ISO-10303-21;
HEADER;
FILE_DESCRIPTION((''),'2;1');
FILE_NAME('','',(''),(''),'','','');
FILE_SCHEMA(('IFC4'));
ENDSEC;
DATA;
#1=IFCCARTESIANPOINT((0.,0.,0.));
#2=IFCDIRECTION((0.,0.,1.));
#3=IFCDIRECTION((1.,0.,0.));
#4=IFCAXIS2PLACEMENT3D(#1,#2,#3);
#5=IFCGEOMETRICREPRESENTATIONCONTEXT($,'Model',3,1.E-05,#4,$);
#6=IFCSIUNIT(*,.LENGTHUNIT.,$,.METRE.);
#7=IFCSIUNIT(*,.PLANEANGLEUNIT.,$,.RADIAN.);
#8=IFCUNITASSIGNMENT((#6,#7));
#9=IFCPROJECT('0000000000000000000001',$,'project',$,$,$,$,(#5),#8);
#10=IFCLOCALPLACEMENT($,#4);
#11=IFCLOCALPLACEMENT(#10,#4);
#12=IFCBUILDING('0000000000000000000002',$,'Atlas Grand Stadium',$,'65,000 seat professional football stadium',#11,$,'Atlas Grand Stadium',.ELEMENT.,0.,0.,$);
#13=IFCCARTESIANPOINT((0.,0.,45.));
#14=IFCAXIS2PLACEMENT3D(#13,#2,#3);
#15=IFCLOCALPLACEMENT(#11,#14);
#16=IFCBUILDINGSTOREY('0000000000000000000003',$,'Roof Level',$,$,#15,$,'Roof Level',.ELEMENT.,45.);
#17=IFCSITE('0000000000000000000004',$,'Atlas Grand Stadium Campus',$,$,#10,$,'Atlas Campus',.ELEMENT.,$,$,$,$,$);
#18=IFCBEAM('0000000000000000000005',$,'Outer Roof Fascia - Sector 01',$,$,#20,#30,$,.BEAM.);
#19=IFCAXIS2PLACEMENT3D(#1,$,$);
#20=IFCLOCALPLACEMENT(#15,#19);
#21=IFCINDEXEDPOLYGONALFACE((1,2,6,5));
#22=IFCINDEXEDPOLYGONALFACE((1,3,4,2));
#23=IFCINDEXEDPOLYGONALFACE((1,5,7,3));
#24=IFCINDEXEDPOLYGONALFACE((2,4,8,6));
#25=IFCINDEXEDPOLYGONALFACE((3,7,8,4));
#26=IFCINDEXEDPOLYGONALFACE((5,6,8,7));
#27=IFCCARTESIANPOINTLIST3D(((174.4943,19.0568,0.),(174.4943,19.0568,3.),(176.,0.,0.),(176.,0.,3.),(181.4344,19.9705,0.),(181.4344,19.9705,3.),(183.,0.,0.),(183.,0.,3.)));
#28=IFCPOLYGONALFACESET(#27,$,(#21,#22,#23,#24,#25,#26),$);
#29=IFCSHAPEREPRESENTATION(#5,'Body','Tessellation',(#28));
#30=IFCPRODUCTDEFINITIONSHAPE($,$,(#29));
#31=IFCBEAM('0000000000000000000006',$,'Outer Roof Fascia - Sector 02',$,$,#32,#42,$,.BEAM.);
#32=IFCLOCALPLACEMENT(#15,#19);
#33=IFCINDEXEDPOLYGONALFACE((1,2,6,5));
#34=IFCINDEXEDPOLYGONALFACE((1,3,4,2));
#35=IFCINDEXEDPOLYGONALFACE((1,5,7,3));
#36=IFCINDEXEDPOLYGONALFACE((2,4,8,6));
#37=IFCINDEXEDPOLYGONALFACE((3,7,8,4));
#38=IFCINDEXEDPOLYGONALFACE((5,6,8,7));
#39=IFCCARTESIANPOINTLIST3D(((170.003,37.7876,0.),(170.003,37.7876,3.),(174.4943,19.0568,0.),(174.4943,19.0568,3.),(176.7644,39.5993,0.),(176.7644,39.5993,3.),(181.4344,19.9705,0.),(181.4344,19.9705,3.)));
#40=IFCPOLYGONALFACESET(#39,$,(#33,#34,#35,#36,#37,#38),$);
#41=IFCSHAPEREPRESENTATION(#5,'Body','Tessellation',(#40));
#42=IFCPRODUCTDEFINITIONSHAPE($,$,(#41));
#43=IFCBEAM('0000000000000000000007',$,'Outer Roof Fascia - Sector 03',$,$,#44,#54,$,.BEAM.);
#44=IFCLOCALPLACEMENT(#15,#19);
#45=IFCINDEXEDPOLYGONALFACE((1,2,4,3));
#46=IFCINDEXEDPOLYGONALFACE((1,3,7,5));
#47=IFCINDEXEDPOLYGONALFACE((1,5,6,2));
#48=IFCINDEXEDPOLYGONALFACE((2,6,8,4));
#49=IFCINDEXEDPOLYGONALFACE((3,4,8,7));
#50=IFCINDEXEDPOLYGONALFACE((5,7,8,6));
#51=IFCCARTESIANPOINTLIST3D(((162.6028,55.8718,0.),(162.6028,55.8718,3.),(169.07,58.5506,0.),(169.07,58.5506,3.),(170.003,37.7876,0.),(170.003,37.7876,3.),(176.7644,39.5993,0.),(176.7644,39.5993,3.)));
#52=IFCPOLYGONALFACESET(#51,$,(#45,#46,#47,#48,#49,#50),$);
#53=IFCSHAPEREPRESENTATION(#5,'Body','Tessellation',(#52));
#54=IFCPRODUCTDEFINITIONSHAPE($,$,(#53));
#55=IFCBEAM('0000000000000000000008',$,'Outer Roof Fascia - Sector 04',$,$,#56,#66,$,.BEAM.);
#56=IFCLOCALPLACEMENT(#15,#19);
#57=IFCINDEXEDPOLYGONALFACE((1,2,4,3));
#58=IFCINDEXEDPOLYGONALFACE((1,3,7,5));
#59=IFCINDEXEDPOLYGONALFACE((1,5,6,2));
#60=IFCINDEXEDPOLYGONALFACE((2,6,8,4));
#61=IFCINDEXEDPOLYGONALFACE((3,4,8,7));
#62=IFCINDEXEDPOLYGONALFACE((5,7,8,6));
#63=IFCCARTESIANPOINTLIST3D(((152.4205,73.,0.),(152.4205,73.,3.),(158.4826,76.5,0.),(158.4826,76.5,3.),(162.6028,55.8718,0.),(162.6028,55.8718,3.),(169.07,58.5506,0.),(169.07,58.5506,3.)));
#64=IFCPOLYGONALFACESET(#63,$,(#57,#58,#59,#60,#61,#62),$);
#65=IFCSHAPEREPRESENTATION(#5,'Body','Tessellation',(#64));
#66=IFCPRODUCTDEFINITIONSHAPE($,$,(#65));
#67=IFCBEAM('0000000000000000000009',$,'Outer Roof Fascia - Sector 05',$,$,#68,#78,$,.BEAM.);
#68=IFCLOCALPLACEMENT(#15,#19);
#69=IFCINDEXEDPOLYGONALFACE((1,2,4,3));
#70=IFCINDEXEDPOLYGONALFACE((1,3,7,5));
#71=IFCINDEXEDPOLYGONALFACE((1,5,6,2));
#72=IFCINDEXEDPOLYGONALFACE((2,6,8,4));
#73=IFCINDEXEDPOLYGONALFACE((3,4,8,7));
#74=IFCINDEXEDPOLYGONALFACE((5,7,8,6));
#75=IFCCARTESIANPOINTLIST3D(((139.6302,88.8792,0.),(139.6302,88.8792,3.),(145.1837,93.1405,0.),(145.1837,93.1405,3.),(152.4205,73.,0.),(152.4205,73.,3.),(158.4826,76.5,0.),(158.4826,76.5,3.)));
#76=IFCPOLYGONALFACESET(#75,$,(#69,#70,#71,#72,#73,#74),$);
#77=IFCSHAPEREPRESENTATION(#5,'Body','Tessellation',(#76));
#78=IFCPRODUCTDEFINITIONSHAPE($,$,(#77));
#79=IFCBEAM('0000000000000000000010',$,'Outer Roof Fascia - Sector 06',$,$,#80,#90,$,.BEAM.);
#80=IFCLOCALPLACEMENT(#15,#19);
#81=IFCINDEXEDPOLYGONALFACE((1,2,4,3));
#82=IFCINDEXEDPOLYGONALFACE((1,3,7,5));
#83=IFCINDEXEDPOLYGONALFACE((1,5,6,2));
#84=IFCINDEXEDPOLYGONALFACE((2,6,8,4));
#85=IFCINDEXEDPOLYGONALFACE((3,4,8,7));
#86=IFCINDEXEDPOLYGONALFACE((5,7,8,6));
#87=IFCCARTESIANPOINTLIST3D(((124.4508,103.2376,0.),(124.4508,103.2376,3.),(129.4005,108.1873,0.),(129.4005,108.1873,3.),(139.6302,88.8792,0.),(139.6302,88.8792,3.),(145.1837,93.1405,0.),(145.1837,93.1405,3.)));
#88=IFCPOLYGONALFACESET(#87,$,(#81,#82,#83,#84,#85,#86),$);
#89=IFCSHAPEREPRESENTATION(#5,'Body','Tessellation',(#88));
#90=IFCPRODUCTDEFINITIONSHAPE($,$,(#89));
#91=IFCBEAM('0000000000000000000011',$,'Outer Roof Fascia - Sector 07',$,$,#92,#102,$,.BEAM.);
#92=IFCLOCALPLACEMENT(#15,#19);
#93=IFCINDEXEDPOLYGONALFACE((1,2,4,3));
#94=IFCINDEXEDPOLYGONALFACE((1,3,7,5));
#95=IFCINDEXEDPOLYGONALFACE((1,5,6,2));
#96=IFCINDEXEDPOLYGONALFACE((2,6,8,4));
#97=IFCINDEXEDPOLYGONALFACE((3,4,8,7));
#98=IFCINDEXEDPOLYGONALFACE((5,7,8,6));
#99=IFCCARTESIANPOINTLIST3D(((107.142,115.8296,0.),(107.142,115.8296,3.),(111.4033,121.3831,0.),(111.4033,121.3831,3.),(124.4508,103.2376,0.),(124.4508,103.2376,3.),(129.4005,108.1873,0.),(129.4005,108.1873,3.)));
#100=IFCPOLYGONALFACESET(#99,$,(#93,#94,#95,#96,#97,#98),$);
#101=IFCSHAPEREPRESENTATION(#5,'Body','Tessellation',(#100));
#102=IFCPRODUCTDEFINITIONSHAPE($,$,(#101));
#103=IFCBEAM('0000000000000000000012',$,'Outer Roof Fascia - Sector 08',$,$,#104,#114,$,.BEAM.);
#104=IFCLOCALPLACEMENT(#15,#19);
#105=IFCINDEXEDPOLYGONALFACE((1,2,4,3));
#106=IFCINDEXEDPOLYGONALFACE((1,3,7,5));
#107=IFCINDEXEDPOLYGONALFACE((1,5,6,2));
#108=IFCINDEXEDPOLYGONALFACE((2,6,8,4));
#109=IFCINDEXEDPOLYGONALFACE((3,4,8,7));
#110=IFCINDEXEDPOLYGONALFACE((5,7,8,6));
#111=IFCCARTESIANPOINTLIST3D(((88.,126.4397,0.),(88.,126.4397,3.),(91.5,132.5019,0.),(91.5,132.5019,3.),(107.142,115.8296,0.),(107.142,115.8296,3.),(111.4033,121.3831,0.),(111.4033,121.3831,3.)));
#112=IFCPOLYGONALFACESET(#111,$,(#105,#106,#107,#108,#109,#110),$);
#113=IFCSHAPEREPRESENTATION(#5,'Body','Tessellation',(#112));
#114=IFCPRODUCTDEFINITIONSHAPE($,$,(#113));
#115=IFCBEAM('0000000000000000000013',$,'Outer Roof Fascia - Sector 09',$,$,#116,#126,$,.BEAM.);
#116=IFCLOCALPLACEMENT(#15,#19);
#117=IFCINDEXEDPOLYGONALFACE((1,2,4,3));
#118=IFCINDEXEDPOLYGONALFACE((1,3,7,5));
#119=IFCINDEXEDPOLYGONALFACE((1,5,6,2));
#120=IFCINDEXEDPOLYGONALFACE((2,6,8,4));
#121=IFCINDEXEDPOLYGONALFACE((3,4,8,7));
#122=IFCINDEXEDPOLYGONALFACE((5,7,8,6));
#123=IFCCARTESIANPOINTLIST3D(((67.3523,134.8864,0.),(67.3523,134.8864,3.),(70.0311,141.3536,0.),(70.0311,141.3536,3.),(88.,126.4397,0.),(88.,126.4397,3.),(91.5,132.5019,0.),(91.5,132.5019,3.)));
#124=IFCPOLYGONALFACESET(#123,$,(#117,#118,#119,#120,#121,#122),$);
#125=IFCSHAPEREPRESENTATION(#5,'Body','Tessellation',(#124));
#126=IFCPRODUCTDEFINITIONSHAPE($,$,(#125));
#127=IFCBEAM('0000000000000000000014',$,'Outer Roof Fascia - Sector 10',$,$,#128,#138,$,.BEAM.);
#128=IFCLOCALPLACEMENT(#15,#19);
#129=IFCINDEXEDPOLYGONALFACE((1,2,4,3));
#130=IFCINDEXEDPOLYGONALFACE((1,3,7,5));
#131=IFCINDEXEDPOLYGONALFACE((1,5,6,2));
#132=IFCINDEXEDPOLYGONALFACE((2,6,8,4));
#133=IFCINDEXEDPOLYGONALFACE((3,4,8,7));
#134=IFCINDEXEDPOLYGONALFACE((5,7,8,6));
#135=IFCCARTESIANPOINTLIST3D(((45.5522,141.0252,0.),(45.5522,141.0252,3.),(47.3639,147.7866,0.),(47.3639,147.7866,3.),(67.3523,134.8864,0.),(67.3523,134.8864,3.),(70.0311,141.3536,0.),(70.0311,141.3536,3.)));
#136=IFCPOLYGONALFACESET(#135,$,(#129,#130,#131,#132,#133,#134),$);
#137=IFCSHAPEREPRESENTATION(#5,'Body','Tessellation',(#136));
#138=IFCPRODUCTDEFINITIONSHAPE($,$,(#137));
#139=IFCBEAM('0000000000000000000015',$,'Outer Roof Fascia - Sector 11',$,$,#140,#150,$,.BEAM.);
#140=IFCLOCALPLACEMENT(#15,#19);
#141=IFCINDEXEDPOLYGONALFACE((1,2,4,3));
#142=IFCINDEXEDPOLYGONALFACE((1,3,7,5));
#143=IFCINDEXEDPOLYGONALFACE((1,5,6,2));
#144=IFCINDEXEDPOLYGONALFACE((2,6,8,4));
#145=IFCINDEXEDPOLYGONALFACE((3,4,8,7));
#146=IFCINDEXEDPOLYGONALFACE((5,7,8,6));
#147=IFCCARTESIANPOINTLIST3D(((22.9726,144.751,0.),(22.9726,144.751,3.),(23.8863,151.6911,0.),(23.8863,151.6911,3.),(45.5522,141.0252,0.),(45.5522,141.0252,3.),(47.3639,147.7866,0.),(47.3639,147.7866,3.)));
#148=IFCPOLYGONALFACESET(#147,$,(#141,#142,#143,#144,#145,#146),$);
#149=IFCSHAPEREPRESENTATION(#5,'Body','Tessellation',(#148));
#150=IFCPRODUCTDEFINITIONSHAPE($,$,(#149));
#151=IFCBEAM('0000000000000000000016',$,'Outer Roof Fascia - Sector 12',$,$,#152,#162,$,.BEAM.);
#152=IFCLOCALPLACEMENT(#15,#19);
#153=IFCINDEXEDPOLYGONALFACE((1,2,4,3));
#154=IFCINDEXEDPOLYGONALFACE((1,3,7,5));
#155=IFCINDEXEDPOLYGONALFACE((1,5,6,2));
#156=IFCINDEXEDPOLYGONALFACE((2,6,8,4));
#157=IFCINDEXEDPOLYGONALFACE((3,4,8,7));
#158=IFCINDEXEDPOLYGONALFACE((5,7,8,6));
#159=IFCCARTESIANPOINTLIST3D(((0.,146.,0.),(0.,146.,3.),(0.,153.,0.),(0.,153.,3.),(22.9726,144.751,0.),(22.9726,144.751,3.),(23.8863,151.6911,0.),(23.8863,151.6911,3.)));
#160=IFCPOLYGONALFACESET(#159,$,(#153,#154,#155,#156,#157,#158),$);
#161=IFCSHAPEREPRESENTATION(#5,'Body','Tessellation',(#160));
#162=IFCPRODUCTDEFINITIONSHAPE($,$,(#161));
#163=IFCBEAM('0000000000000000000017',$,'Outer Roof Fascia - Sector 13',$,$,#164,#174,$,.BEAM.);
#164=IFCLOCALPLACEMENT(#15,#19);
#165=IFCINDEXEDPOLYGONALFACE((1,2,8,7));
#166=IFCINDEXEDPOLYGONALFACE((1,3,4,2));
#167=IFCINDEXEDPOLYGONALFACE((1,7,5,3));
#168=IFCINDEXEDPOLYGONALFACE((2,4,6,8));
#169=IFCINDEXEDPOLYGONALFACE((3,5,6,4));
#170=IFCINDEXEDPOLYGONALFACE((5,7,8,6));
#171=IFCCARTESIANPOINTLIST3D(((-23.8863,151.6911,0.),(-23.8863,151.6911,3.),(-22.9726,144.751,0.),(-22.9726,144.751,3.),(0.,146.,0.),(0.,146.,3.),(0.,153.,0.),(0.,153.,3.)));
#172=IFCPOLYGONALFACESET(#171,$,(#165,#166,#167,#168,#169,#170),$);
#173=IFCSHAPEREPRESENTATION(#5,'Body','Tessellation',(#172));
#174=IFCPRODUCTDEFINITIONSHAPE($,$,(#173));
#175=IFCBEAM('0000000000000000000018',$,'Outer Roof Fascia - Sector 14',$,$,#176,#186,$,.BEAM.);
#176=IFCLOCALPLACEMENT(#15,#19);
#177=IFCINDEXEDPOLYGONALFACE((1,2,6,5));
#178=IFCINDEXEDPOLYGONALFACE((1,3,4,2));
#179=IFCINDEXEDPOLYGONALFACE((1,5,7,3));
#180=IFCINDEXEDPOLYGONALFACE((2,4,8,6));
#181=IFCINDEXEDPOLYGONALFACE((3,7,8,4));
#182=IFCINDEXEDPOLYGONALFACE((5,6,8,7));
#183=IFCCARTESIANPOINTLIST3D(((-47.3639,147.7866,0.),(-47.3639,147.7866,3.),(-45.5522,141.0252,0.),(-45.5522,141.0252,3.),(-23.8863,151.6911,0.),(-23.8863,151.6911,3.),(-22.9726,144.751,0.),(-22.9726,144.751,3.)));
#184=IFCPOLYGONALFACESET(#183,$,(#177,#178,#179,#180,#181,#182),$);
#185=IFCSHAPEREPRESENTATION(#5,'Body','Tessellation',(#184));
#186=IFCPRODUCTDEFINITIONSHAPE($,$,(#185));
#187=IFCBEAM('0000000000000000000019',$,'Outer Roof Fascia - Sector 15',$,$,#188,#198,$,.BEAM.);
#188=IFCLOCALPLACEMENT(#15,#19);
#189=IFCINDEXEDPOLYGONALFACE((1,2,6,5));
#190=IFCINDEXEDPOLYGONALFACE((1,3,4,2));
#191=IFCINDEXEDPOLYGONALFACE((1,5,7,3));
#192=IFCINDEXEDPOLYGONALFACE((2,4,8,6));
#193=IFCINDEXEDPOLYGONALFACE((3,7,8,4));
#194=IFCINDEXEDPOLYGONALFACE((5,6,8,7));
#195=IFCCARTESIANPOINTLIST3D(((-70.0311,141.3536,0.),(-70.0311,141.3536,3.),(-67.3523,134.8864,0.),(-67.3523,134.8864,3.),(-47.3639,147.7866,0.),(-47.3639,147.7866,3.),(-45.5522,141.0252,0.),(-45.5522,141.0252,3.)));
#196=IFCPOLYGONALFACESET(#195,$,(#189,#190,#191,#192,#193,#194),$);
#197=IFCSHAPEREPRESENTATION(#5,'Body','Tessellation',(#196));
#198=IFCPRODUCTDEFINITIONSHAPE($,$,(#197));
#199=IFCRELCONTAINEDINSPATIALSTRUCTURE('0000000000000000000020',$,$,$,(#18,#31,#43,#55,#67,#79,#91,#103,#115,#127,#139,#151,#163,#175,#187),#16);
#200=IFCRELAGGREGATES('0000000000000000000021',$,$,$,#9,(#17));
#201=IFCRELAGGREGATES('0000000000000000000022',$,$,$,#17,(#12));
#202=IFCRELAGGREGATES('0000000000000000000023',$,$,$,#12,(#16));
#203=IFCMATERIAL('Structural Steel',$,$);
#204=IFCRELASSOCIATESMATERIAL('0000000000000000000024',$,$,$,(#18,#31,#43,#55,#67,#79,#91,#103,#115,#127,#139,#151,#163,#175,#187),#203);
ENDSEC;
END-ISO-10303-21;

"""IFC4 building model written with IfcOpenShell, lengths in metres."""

from ifc_helpers import new_model, si_unit, frame, origin_with_axes, place, context, project, spatial, polyline, outline, extrude, material, element, save


model = new_model("IFC4")

# Units and contexts
model_context = context("Model", 3, precision=1e-05, world=origin_with_axes())
ifc_project = project(units=[si_unit("LENGTHUNIT", "METRE"), si_unit("PLANEANGLEUNIT", "RADIAN")], contexts=[model_context])

# Site, building, storey
site_placement = place(None, origin_with_axes())
site = spatial("IfcSite", under=ifc_project, at=site_placement, Name="Atlas Grand Stadium Campus", LongName="Atlas Campus", CompositionType="ELEMENT")
building_placement = place(site_placement, origin_with_axes())
building = spatial("IfcBuilding", under=site, at=building_placement, Name="Atlas Grand Stadium", ObjectType="65,000 seat professional football stadium", LongName="Atlas Grand Stadium", CompositionType="ELEMENT", ElevationOfRefHeight=0.0, ElevationOfTerrain=0.0)
storey_placement = place(building_placement, frame((0.0, 0.0, 45.0), z_axis=(0.0, 0.0, 1.0), x_axis=(1.0, 0.0, 0.0)))
storey = spatial("IfcBuildingStorey", under=building, at=storey_placement, Name="Roof Level", LongName="Roof Level", CompositionType="ELEMENT", Elevation=45.0)

# Beams
ifc_material_1 = material(Name="Structural Steel")
beam_1_placement = place(storey_placement, origin_with_axes())
element("IfcBeam", 1, at=beam_1_placement, inside=storey, material=ifc_material_1, Name="Outer Roof Fascia - Sector 01", PredefinedType="BEAM", context=model_context, shape_type="SweptSolid", body=[
    extrude(outline(polyline([(183.0, 0.0), (181.4344, 19.9705), (174.4943, 19.0568), (176.0, 0.0), (183.0, 0.0)])), origin_with_axes(), (0.0, 0.0, 1.0), 3.0),
])
beam_2_placement = place(storey_placement, origin_with_axes())
element("IfcBeam", 2, at=beam_2_placement, inside=storey, material=ifc_material_1, Name="Outer Roof Fascia - Sector 02", PredefinedType="BEAM", context=model_context, shape_type="SweptSolid", body=[
    extrude(outline(polyline([(181.4344, 19.9705), (176.7644, 39.5993), (170.0029, 37.7876), (174.4943, 19.0568), (181.4344, 19.9705)])), origin_with_axes(), (0.0, 0.0, 1.0), 3.0),
])
beam_3_placement = place(storey_placement, origin_with_axes())
element("IfcBeam", 3, at=beam_3_placement, inside=storey, material=ifc_material_1, Name="Outer Roof Fascia - Sector 03", PredefinedType="BEAM", context=model_context, shape_type="SweptSolid", body=[
    extrude(outline(polyline([(176.7644, 39.5993), (169.07, 58.5506), (162.6028, 55.8718), (170.0029, 37.7876), (176.7644, 39.5993)])), origin_with_axes(), (0.0, 0.0, 1.0), 3.0),
])
beam_4_placement = place(storey_placement, origin_with_axes())
element("IfcBeam", 4, at=beam_4_placement, inside=storey, material=ifc_material_1, Name="Outer Roof Fascia - Sector 04", PredefinedType="BEAM", context=model_context, shape_type="SweptSolid", body=[
    extrude(outline(polyline([(169.07, 58.5506), (158.4827, 76.5), (152.4205, 73.0), (162.6028, 55.8718), (169.07, 58.5506)])), origin_with_axes(), (0.0, 0.0, 1.0), 3.0),
])
beam_5_placement = place(storey_placement, origin_with_axes())
element("IfcBeam", 5, at=beam_5_placement, inside=storey, material=ifc_material_1, Name="Outer Roof Fascia - Sector 05", PredefinedType="BEAM", context=model_context, shape_type="SweptSolid", body=[
    extrude(outline(polyline([(158.4827, 76.5), (145.1837, 93.1405), (139.6302, 88.8792), (152.4205, 73.0), (158.4827, 76.5)])), origin_with_axes(), (0.0, 0.0, 1.0), 3.0),
])
beam_6_placement = place(storey_placement, origin_with_axes())
element("IfcBeam", 6, at=beam_6_placement, inside=storey, material=ifc_material_1, Name="Outer Roof Fascia - Sector 06", PredefinedType="BEAM", context=model_context, shape_type="SweptSolid", body=[
    extrude(outline(polyline([(145.1837, 93.1405), (129.4005, 108.1873), (124.4508, 103.2376), (139.6302, 88.8792), (145.1837, 93.1405)])), origin_with_axes(), (0.0, 0.0, 1.0), 3.0),
])
beam_7_placement = place(storey_placement, origin_with_axes())
element("IfcBeam", 7, at=beam_7_placement, inside=storey, material=ifc_material_1, Name="Outer Roof Fascia - Sector 07", PredefinedType="BEAM", context=model_context, shape_type="SweptSolid", body=[
    extrude(outline(polyline([(129.4005, 108.1873), (111.4033, 121.3831), (107.142, 115.8296), (124.4508, 103.2376), (129.4005, 108.1873)])), origin_with_axes(), (0.0, 0.0, 1.0), 3.0),
])
beam_8_placement = place(storey_placement, origin_with_axes())
element("IfcBeam", 8, at=beam_8_placement, inside=storey, material=ifc_material_1, Name="Outer Roof Fascia - Sector 08", PredefinedType="BEAM", context=model_context, shape_type="SweptSolid", body=[
    extrude(outline(polyline([(111.4033, 121.3831), (91.5, 132.5019), (88.0, 126.4397), (107.142, 115.8296), (111.4033, 121.3831)])), origin_with_axes(), (0.0, 0.0, 1.0), 3.0),
])
beam_9_placement = place(storey_placement, origin_with_axes())
element("IfcBeam", 9, at=beam_9_placement, inside=storey, material=ifc_material_1, Name="Outer Roof Fascia - Sector 09", PredefinedType="BEAM", context=model_context, shape_type="SweptSolid", body=[
    extrude(outline(polyline([(91.5, 132.5019), (70.0311, 141.3536), (67.3523, 134.8864), (88.0, 126.4397), (91.5, 132.5019)])), origin_with_axes(), (0.0, 0.0, 1.0), 3.0),
])
beam_10_placement = place(storey_placement, origin_with_axes())
element("IfcBeam", 10, at=beam_10_placement, inside=storey, material=ifc_material_1, Name="Outer Roof Fascia - Sector 10", PredefinedType="BEAM", context=model_context, shape_type="SweptSolid", body=[
    extrude(outline(polyline([(70.0311, 141.3536), (47.3639, 147.7867), (45.5521, 141.0252), (67.3523, 134.8864), (70.0311, 141.3536)])), origin_with_axes(), (0.0, 0.0, 1.0), 3.0),
])
beam_11_placement = place(storey_placement, origin_with_axes())
element("IfcBeam", 11, at=beam_11_placement, inside=storey, material=ifc_material_1, Name="Outer Roof Fascia - Sector 11", PredefinedType="BEAM", context=model_context, shape_type="SweptSolid", body=[
    extrude(outline(polyline([(47.3639, 147.7867), (23.8863, 151.6911), (22.9726, 144.7509), (45.5521, 141.0252), (47.3639, 147.7867)])), origin_with_axes(), (0.0, 0.0, 1.0), 3.0),
])
beam_12_placement = place(storey_placement, origin_with_axes())
element("IfcBeam", 12, at=beam_12_placement, inside=storey, material=ifc_material_1, Name="Outer Roof Fascia - Sector 12", PredefinedType="BEAM", context=model_context, shape_type="SweptSolid", body=[
    extrude(outline(polyline([(23.8863, 151.6911), (0.0, 153.0), (0.0, 146.0), (22.9726, 144.7509), (23.8863, 151.6911)])), origin_with_axes(), (0.0, 0.0, 1.0), 3.0),
])
beam_13_placement = place(storey_placement, origin_with_axes())
element("IfcBeam", 13, at=beam_13_placement, inside=storey, material=ifc_material_1, Name="Outer Roof Fascia - Sector 13", PredefinedType="BEAM", context=model_context, shape_type="SweptSolid", body=[
    extrude(outline(polyline([(0.0, 153.0), (-23.8863, 151.6911), (-22.9726, 144.7509), (0.0, 146.0), (0.0, 153.0)])), origin_with_axes(), (0.0, 0.0, 1.0), 3.0),
])
beam_14_placement = place(storey_placement, origin_with_axes())
element("IfcBeam", 14, at=beam_14_placement, inside=storey, material=ifc_material_1, Name="Outer Roof Fascia - Sector 14", PredefinedType="BEAM", context=model_context, shape_type="SweptSolid", body=[
    extrude(outline(polyline([(-23.8863, 151.6911), (-47.3639, 147.7867), (-45.5521, 141.0252), (-22.9726, 144.7509), (-23.8863, 151.6911)])), origin_with_axes(), (0.0, 0.0, 1.0), 3.0),
])
beam_15_placement = place(storey_placement, origin_with_axes())
element("IfcBeam", 15, at=beam_15_placement, inside=storey, material=ifc_material_1, Name="Outer Roof Fascia - Sector 15", PredefinedType="BEAM", context=model_context, shape_type="SweptSolid", body=[
    extrude(outline(polyline([(-47.3639, 147.7867), (-70.0311, 141.3536), (-67.3523, 134.8864), (-45.5521, 141.0252), (-47.3639, 147.7867)])), origin_with_axes(), (0.0, 0.0, 1.0), 3.0),
])

save(model, "model.ifc")
